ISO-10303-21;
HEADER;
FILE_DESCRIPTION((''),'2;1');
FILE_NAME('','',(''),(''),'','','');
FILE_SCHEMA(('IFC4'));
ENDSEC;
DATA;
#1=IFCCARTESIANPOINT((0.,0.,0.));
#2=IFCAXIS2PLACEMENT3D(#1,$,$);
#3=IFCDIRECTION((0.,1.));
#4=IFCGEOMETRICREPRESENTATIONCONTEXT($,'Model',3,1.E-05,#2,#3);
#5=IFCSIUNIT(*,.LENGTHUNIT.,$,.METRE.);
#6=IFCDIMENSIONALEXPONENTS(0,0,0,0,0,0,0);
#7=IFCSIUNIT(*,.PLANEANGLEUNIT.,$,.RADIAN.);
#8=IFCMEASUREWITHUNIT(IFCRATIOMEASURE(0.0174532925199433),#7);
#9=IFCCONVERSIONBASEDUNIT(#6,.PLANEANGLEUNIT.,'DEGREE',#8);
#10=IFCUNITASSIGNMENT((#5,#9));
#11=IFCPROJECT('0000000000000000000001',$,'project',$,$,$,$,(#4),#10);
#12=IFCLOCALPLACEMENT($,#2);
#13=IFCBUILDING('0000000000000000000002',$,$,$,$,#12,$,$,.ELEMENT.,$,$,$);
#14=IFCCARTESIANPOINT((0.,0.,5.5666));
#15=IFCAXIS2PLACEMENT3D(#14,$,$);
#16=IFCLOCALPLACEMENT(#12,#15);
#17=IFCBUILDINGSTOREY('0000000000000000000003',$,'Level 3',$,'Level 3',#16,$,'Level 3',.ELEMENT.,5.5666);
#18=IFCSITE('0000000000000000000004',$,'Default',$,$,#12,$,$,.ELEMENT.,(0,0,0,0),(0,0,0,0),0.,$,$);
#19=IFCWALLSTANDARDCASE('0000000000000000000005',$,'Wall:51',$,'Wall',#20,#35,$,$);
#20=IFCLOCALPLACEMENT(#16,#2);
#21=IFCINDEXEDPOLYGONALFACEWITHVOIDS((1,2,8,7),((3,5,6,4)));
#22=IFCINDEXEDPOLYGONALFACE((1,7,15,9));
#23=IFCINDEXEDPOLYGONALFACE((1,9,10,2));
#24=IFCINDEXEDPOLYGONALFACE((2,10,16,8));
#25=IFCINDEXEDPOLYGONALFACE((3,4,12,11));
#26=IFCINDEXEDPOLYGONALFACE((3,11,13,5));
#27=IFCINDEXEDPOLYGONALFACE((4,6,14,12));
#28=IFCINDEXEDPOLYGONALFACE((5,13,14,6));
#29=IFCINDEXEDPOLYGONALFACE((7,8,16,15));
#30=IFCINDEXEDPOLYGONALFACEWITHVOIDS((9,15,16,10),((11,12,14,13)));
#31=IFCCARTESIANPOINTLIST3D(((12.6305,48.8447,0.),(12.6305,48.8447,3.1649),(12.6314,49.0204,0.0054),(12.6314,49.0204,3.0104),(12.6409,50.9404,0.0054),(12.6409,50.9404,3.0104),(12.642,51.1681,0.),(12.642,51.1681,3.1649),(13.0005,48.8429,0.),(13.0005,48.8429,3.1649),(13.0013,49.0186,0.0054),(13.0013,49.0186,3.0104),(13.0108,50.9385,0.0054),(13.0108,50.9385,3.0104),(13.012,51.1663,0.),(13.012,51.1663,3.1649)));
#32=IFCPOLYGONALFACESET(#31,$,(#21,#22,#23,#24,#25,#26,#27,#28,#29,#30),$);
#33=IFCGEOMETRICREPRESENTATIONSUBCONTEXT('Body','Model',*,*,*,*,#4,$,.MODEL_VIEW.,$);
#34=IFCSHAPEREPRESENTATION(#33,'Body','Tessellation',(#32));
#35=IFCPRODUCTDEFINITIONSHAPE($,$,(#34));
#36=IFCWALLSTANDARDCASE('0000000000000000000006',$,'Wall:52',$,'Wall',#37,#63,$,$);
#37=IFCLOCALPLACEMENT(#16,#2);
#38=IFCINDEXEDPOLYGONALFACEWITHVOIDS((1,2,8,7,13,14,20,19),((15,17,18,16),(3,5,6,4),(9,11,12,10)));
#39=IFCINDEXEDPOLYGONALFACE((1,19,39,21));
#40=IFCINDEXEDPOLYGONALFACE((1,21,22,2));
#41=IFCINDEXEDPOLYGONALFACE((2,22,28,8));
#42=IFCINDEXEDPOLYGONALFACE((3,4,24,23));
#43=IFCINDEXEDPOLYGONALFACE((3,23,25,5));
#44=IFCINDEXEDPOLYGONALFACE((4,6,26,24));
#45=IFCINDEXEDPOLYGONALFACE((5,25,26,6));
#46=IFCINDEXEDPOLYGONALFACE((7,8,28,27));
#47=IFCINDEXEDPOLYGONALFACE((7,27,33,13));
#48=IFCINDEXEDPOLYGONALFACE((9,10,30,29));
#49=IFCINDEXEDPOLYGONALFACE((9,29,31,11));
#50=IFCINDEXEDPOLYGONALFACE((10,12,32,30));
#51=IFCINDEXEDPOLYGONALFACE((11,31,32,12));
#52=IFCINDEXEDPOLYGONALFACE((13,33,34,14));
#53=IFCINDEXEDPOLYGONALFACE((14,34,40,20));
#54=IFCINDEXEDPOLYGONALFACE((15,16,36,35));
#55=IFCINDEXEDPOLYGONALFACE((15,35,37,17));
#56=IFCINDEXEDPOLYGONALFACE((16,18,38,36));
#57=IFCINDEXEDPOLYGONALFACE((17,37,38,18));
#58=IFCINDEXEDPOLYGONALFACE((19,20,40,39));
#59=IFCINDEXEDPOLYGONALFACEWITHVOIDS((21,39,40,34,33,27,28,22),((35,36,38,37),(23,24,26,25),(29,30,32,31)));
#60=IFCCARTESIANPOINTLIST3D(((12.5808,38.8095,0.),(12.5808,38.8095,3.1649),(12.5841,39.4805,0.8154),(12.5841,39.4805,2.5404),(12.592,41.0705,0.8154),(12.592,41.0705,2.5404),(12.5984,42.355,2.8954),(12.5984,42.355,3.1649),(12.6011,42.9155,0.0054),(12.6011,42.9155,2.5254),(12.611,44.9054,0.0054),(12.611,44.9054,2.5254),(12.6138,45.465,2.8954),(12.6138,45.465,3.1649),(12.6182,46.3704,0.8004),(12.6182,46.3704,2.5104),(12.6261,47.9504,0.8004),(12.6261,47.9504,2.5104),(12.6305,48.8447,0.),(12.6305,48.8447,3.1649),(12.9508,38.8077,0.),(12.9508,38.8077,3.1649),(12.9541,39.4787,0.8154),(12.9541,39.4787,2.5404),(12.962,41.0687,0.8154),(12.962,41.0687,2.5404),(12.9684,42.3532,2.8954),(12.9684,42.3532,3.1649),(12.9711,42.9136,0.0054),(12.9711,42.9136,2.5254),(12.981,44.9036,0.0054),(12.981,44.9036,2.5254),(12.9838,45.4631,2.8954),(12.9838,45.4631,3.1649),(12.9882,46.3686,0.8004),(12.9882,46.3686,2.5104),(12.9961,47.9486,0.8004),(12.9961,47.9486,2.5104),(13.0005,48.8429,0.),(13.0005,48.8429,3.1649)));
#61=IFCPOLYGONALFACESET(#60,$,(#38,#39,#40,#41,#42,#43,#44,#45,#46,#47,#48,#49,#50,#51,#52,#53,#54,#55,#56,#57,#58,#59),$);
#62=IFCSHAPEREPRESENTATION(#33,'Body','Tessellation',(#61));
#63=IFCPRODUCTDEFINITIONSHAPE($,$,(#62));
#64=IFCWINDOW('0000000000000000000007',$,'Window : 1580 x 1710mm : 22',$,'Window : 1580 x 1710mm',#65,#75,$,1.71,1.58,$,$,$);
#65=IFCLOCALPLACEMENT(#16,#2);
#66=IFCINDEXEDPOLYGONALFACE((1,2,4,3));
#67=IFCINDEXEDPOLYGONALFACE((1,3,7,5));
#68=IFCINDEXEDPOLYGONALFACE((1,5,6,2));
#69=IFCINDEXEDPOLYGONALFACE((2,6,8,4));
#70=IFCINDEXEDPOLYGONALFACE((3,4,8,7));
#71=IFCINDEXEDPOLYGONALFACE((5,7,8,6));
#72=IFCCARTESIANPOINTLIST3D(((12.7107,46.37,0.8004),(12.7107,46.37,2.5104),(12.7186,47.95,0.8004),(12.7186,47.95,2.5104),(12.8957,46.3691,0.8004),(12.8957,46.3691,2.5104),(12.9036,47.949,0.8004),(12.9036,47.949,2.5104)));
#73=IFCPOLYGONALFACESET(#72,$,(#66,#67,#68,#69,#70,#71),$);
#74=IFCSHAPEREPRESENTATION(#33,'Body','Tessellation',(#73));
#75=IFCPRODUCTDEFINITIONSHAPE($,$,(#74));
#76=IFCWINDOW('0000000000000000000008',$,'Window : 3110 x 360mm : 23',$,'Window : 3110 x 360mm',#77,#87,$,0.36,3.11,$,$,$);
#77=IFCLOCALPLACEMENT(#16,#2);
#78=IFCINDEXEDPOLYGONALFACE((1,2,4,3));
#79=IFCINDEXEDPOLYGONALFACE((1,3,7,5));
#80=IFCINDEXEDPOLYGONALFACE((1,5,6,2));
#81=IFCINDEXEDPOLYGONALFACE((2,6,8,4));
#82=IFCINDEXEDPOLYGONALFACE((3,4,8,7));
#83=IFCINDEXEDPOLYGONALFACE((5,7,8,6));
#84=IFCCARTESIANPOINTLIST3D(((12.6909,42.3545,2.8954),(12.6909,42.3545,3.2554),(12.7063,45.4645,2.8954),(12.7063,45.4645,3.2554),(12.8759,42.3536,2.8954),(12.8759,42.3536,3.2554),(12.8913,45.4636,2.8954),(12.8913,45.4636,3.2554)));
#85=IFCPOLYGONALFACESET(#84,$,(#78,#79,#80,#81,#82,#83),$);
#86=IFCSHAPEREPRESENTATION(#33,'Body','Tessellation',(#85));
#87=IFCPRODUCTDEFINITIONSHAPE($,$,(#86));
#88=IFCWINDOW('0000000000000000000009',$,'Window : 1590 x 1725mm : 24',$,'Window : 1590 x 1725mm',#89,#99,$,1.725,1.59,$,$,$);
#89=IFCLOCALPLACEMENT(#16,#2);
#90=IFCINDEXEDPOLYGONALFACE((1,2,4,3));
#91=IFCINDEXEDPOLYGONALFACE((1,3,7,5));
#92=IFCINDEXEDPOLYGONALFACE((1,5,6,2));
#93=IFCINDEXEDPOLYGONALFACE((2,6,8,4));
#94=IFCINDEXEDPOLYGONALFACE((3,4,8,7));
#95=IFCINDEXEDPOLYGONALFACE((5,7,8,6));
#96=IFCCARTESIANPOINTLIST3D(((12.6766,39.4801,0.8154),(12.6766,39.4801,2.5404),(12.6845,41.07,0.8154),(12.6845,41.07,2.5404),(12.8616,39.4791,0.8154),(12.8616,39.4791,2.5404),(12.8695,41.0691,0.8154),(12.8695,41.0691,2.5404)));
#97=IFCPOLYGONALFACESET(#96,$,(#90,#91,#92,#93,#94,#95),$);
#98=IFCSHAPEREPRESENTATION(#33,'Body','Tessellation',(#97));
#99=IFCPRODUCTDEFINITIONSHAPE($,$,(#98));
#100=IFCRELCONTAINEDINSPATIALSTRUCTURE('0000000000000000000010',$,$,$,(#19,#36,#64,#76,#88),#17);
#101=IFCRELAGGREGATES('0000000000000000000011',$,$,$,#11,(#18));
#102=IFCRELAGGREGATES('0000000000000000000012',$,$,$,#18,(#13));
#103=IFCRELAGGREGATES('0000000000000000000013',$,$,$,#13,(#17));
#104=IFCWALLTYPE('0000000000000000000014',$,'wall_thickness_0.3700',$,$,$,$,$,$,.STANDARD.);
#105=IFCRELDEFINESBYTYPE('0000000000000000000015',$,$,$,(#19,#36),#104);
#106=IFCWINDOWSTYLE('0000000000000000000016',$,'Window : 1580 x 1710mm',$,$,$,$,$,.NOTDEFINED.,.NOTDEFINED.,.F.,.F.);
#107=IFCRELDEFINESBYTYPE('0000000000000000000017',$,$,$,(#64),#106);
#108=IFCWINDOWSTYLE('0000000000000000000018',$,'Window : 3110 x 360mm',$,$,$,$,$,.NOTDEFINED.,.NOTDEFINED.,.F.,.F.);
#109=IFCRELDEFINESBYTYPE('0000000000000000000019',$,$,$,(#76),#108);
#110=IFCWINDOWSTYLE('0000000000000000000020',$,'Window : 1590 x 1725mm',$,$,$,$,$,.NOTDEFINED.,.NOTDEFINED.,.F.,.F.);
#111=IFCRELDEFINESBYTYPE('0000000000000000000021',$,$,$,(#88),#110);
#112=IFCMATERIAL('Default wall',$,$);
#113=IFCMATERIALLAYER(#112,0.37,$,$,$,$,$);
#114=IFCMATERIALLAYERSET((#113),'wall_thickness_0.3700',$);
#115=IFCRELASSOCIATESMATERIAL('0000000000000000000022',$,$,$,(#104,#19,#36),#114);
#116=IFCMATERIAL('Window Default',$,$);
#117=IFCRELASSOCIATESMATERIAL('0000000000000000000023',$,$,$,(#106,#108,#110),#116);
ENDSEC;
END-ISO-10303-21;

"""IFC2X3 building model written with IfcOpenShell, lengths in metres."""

from ifc_helpers import new_model, entity, si_unit, converted_unit, direction, frame, frame_2d, origin, origin_2d_with_axis, place, context, subcontext, project, spatial, polyline, rectangle, outline, extrude, source, transform, mapped, material, layer, layer_set, layer_usage, type_object, type_shapes, element, fill, save


model = new_model("IFC2X3")

# Units and contexts
model_context = context("Model", 3, precision=1e-05, world=origin(), true_north=direction((0.0, 1.0)))
body_context = subcontext(model_context, "Body", "Model", "MODEL_VIEW")
ifc_project = project(units=[si_unit("LENGTHUNIT", "METRE"), converted_unit("PLANEANGLEUNIT", "DEGREE", entity("IfcRatioMeasure", 0.0174532925199433), si_unit("PLANEANGLEUNIT", "RADIAN"), dimensions=[0, 0, 0, 0, 0, 0, 0])], contexts=[model_context])

# Site, building, storey
placement = place(None, origin())
site = spatial("IfcSite", under=ifc_project, at=placement, Name="Default", CompositionType="ELEMENT", RefLatitude=(0, 0, 0, 0), RefLongitude=(0, 0, 0, 0), RefElevation=0.0)
building = spatial("IfcBuilding", under=site, at=placement, CompositionType="ELEMENT")
storey_placement = place(placement, frame((0.0, 0.0, 5.5666)))
storey = spatial("IfcBuildingStorey", under=building, at=storey_placement, Name="Level 3", ObjectType="Level 3", LongName="Level 3", CompositionType="ELEMENT", Elevation=5.5666)

# Shared definitions
ifc_material_1 = material(Name="Default wall")
ifc_material_2 = material(Name="Window Default")

# Wall, opening
ifc_layer_1 = layer(ifc_material_1, 0.37)
ifc_layer_set_1 = layer_set([ifc_layer_1], Name="wall_thickness_0.3700")
ifc_layer_usage_1 = layer_usage(ifc_layer_set_1, "AXIS2", "POSITIVE", -0.185)
wall_type_1 = type_object("IfcWallType", Name="wall_thickness_0.3700", PredefinedType="STANDARD", material=ifc_layer_set_1)
wall_1_placement = place(storey_placement, frame((12.827, 51.1672, 0.0), z_axis=(0.0, 0.0, 1.0), x_axis=(-0.004948, -0.999988, 0.0)))
wall_1 = element("IfcWallStandardCase", 1, at=wall_1_placement, inside=storey, type_object=wall_type_1, material=ifc_layer_usage_1, Name="Wall:51", ObjectType="Wall", context=body_context, shape_type="SweptSolid", body=[
    extrude(outline(polyline([(2.3235, -0.185), (2.3235, 0.185), (0.0, 0.185), (0.0, -0.185), (2.3235, -0.185)])), origin(), (0.0, 0.0, 1.0), 3.1649),
])
opening_1_placement = place(wall_1_placement, frame((0.2278, -0.185, 0.0054)))
element("IfcOpeningElement", 2, at=opening_1_placement, cuts=wall_1, ObjectType="Opening", context=body_context, shape_type="SweptSolid", body=[
    extrude(rectangle(XDim=1.92, YDim=3.005, at=frame_2d((1.5025, 0.96), x_axis=(0.0, 1.0))), frame((0.0, 0.0, 0.0), z_axis=(0.0, 1.0, 0.0), x_axis=(0.0, 0.0, 1.0)), (0.0, 0.0, 1.0), 0.37),
])

# Wall, openings, windows
wall_2_placement = place(storey_placement, frame((12.8155, 48.8438, 0.0), z_axis=(0.0, 0.0, 1.0), x_axis=(-0.004948, -0.999988, 0.0)))
wall_2 = element("IfcWallStandardCase", 3, at=wall_2_placement, inside=storey, type_object=wall_type_1, material=ifc_layer_usage_1, Name="Wall:52", ObjectType="Wall", context=body_context, shape_type="SweptSolid", body=[
    extrude(outline(polyline([(10.0353, -0.185), (10.0353, 0.185), (0.0, 0.185), (0.0, -0.185), (10.0353, -0.185)])), origin(), (0.0, 0.0, 1.0), 3.1649),
])
opening_2_placement = place(wall_2_placement, frame((3.9393, -0.185, 0.0054)))
element("IfcOpeningElement", 4, at=opening_2_placement, cuts=wall_2, ObjectType="Opening", context=body_context, shape_type="SweptSolid", body=[
    extrude(rectangle(XDim=1.99, YDim=2.52, at=frame_2d((1.26, 0.995), x_axis=(0.0, 1.0))), frame((0.0, 0.0, 0.0), z_axis=(0.0, 1.0, 0.0), x_axis=(0.0, 0.0, 1.0)), (0.0, 0.0, 1.0), 0.37),
])
opening_3_placement = place(wall_2_placement, frame((0.8943, -0.185, 0.8004)))
opening_3 = element("IfcOpeningElement", 5, at=opening_3_placement, cuts=wall_2, ObjectType="Opening", context=body_context, shape_type="SweptSolid", body=[
    extrude(rectangle(XDim=1.58, YDim=1.71, at=frame_2d((0.855, 0.79), x_axis=(0.0, 1.0))), frame((0.0, 0.0, 0.0), z_axis=(0.0, 1.0, 0.0), x_axis=(0.0, 0.0, 1.0)), (0.0, 0.0, 1.0), 0.37),
])
opening_4_placement = place(wall_2_placement, frame((3.3798, -0.185, 2.8954)))
opening_4 = element("IfcOpeningElement", 6, at=opening_4_placement, cuts=wall_2, ObjectType="Opening", context=body_context, shape_type="SweptSolid", body=[
    extrude(rectangle(XDim=3.11, YDim=0.36, at=frame_2d((0.18, 1.555), x_axis=(0.0, 1.0))), frame((0.0, 0.0, 0.0), z_axis=(0.0, 1.0, 0.0), x_axis=(0.0, 0.0, 1.0)), (0.0, 0.0, 1.0), 0.37),
])
opening_5_placement = place(wall_2_placement, frame((7.7743, -0.185, 0.8154)))
opening_5 = element("IfcOpeningElement", 7, at=opening_5_placement, cuts=wall_2, ObjectType="Opening", context=body_context, shape_type="SweptSolid", body=[
    extrude(rectangle(XDim=1.59, YDim=1.725, at=frame_2d((0.8625, 0.795), x_axis=(0.0, 1.0))), frame((0.0, 0.0, 0.0), z_axis=(0.0, 1.0, 0.0), x_axis=(0.0, 0.0, 1.0)), (0.0, 0.0, 1.0), 0.37),
])
window_style_1 = type_object("IfcWindowStyle", Name="Window : 1580 x 1710mm", ConstructionType="NOTDEFINED", OperationType="NOTDEFINED", ParameterTakesPrecedence=False, Sizeable=False, material=ifc_material_2)
shared_shape_1 = source(origin(), body_context, "Body", "SweptSolid", [
    extrude(rectangle(XDim=0.185, YDim=1.58, at=origin_2d_with_axis()), frame((0.79, 0.185, 0.0), z_axis=(0.0, 0.0, 1.0), x_axis=(0.0, 1.0, 0.0)), (0.0, 0.0, 1.0), 1.71),
])
type_shapes(window_style_1, [shared_shape_1])
window_1_placement = place(opening_3_placement, origin())
window_1 = element("IfcWindow", 8, at=window_1_placement, inside=storey, type_object=window_style_1, Name="Window : 1580 x 1710mm : 22", ObjectType="Window : 1580 x 1710mm", OverallHeight=1.71, OverallWidth=1.58, context=body_context, shape_type="MappedRepresentation", body=[
    mapped(shared_shape_1, transform((0.0, 0.0, 0.0), scale=1.0)),
])
fill(opening_3, window_1)
window_style_2 = type_object("IfcWindowStyle", Name="Window : 3110 x 360mm", ConstructionType="NOTDEFINED", OperationType="NOTDEFINED", ParameterTakesPrecedence=False, Sizeable=False, material=ifc_material_2)
shared_shape_2 = source(origin(), body_context, "Body", "SweptSolid", [
    extrude(rectangle(XDim=0.185, YDim=3.11, at=origin_2d_with_axis()), frame((1.555, 0.185, 0.0), z_axis=(0.0, 0.0, 1.0), x_axis=(0.0, 1.0, 0.0)), (0.0, 0.0, 1.0), 0.36),
])
type_shapes(window_style_2, [shared_shape_2])
window_2_placement = place(opening_4_placement, origin())
window_2 = element("IfcWindow", 9, at=window_2_placement, inside=storey, type_object=window_style_2, Name="Window : 3110 x 360mm : 23", ObjectType="Window : 3110 x 360mm", OverallHeight=0.36, OverallWidth=3.11, context=body_context, shape_type="MappedRepresentation", body=[
    mapped(shared_shape_2, transform((0.0, 0.0, 0.0), scale=1.0)),
])
fill(opening_4, window_2)
window_style_3 = type_object("IfcWindowStyle", Name="Window : 1590 x 1725mm", ConstructionType="NOTDEFINED", OperationType="NOTDEFINED", ParameterTakesPrecedence=False, Sizeable=False, material=ifc_material_2)
shared_shape_3 = source(origin(), body_context, "Body", "SweptSolid", [
    extrude(rectangle(XDim=0.185, YDim=1.59, at=origin_2d_with_axis()), frame((0.795, 0.185, 0.0), z_axis=(0.0, 0.0, 1.0), x_axis=(0.0, 1.0, 0.0)), (0.0, 0.0, 1.0), 1.725),
])
type_shapes(window_style_3, [shared_shape_3])
window_3_placement = place(opening_5_placement, origin())
window_3 = element("IfcWindow", 10, at=window_3_placement, inside=storey, type_object=window_style_3, Name="Window : 1590 x 1725mm : 24", ObjectType="Window : 1590 x 1725mm", OverallHeight=1.725, OverallWidth=1.59, context=body_context, shape_type="MappedRepresentation", body=[
    mapped(shared_shape_3, transform((0.0, 0.0, 0.0), scale=1.0)),
])
fill(opening_5, window_3)

save(model, "model.ifc")
